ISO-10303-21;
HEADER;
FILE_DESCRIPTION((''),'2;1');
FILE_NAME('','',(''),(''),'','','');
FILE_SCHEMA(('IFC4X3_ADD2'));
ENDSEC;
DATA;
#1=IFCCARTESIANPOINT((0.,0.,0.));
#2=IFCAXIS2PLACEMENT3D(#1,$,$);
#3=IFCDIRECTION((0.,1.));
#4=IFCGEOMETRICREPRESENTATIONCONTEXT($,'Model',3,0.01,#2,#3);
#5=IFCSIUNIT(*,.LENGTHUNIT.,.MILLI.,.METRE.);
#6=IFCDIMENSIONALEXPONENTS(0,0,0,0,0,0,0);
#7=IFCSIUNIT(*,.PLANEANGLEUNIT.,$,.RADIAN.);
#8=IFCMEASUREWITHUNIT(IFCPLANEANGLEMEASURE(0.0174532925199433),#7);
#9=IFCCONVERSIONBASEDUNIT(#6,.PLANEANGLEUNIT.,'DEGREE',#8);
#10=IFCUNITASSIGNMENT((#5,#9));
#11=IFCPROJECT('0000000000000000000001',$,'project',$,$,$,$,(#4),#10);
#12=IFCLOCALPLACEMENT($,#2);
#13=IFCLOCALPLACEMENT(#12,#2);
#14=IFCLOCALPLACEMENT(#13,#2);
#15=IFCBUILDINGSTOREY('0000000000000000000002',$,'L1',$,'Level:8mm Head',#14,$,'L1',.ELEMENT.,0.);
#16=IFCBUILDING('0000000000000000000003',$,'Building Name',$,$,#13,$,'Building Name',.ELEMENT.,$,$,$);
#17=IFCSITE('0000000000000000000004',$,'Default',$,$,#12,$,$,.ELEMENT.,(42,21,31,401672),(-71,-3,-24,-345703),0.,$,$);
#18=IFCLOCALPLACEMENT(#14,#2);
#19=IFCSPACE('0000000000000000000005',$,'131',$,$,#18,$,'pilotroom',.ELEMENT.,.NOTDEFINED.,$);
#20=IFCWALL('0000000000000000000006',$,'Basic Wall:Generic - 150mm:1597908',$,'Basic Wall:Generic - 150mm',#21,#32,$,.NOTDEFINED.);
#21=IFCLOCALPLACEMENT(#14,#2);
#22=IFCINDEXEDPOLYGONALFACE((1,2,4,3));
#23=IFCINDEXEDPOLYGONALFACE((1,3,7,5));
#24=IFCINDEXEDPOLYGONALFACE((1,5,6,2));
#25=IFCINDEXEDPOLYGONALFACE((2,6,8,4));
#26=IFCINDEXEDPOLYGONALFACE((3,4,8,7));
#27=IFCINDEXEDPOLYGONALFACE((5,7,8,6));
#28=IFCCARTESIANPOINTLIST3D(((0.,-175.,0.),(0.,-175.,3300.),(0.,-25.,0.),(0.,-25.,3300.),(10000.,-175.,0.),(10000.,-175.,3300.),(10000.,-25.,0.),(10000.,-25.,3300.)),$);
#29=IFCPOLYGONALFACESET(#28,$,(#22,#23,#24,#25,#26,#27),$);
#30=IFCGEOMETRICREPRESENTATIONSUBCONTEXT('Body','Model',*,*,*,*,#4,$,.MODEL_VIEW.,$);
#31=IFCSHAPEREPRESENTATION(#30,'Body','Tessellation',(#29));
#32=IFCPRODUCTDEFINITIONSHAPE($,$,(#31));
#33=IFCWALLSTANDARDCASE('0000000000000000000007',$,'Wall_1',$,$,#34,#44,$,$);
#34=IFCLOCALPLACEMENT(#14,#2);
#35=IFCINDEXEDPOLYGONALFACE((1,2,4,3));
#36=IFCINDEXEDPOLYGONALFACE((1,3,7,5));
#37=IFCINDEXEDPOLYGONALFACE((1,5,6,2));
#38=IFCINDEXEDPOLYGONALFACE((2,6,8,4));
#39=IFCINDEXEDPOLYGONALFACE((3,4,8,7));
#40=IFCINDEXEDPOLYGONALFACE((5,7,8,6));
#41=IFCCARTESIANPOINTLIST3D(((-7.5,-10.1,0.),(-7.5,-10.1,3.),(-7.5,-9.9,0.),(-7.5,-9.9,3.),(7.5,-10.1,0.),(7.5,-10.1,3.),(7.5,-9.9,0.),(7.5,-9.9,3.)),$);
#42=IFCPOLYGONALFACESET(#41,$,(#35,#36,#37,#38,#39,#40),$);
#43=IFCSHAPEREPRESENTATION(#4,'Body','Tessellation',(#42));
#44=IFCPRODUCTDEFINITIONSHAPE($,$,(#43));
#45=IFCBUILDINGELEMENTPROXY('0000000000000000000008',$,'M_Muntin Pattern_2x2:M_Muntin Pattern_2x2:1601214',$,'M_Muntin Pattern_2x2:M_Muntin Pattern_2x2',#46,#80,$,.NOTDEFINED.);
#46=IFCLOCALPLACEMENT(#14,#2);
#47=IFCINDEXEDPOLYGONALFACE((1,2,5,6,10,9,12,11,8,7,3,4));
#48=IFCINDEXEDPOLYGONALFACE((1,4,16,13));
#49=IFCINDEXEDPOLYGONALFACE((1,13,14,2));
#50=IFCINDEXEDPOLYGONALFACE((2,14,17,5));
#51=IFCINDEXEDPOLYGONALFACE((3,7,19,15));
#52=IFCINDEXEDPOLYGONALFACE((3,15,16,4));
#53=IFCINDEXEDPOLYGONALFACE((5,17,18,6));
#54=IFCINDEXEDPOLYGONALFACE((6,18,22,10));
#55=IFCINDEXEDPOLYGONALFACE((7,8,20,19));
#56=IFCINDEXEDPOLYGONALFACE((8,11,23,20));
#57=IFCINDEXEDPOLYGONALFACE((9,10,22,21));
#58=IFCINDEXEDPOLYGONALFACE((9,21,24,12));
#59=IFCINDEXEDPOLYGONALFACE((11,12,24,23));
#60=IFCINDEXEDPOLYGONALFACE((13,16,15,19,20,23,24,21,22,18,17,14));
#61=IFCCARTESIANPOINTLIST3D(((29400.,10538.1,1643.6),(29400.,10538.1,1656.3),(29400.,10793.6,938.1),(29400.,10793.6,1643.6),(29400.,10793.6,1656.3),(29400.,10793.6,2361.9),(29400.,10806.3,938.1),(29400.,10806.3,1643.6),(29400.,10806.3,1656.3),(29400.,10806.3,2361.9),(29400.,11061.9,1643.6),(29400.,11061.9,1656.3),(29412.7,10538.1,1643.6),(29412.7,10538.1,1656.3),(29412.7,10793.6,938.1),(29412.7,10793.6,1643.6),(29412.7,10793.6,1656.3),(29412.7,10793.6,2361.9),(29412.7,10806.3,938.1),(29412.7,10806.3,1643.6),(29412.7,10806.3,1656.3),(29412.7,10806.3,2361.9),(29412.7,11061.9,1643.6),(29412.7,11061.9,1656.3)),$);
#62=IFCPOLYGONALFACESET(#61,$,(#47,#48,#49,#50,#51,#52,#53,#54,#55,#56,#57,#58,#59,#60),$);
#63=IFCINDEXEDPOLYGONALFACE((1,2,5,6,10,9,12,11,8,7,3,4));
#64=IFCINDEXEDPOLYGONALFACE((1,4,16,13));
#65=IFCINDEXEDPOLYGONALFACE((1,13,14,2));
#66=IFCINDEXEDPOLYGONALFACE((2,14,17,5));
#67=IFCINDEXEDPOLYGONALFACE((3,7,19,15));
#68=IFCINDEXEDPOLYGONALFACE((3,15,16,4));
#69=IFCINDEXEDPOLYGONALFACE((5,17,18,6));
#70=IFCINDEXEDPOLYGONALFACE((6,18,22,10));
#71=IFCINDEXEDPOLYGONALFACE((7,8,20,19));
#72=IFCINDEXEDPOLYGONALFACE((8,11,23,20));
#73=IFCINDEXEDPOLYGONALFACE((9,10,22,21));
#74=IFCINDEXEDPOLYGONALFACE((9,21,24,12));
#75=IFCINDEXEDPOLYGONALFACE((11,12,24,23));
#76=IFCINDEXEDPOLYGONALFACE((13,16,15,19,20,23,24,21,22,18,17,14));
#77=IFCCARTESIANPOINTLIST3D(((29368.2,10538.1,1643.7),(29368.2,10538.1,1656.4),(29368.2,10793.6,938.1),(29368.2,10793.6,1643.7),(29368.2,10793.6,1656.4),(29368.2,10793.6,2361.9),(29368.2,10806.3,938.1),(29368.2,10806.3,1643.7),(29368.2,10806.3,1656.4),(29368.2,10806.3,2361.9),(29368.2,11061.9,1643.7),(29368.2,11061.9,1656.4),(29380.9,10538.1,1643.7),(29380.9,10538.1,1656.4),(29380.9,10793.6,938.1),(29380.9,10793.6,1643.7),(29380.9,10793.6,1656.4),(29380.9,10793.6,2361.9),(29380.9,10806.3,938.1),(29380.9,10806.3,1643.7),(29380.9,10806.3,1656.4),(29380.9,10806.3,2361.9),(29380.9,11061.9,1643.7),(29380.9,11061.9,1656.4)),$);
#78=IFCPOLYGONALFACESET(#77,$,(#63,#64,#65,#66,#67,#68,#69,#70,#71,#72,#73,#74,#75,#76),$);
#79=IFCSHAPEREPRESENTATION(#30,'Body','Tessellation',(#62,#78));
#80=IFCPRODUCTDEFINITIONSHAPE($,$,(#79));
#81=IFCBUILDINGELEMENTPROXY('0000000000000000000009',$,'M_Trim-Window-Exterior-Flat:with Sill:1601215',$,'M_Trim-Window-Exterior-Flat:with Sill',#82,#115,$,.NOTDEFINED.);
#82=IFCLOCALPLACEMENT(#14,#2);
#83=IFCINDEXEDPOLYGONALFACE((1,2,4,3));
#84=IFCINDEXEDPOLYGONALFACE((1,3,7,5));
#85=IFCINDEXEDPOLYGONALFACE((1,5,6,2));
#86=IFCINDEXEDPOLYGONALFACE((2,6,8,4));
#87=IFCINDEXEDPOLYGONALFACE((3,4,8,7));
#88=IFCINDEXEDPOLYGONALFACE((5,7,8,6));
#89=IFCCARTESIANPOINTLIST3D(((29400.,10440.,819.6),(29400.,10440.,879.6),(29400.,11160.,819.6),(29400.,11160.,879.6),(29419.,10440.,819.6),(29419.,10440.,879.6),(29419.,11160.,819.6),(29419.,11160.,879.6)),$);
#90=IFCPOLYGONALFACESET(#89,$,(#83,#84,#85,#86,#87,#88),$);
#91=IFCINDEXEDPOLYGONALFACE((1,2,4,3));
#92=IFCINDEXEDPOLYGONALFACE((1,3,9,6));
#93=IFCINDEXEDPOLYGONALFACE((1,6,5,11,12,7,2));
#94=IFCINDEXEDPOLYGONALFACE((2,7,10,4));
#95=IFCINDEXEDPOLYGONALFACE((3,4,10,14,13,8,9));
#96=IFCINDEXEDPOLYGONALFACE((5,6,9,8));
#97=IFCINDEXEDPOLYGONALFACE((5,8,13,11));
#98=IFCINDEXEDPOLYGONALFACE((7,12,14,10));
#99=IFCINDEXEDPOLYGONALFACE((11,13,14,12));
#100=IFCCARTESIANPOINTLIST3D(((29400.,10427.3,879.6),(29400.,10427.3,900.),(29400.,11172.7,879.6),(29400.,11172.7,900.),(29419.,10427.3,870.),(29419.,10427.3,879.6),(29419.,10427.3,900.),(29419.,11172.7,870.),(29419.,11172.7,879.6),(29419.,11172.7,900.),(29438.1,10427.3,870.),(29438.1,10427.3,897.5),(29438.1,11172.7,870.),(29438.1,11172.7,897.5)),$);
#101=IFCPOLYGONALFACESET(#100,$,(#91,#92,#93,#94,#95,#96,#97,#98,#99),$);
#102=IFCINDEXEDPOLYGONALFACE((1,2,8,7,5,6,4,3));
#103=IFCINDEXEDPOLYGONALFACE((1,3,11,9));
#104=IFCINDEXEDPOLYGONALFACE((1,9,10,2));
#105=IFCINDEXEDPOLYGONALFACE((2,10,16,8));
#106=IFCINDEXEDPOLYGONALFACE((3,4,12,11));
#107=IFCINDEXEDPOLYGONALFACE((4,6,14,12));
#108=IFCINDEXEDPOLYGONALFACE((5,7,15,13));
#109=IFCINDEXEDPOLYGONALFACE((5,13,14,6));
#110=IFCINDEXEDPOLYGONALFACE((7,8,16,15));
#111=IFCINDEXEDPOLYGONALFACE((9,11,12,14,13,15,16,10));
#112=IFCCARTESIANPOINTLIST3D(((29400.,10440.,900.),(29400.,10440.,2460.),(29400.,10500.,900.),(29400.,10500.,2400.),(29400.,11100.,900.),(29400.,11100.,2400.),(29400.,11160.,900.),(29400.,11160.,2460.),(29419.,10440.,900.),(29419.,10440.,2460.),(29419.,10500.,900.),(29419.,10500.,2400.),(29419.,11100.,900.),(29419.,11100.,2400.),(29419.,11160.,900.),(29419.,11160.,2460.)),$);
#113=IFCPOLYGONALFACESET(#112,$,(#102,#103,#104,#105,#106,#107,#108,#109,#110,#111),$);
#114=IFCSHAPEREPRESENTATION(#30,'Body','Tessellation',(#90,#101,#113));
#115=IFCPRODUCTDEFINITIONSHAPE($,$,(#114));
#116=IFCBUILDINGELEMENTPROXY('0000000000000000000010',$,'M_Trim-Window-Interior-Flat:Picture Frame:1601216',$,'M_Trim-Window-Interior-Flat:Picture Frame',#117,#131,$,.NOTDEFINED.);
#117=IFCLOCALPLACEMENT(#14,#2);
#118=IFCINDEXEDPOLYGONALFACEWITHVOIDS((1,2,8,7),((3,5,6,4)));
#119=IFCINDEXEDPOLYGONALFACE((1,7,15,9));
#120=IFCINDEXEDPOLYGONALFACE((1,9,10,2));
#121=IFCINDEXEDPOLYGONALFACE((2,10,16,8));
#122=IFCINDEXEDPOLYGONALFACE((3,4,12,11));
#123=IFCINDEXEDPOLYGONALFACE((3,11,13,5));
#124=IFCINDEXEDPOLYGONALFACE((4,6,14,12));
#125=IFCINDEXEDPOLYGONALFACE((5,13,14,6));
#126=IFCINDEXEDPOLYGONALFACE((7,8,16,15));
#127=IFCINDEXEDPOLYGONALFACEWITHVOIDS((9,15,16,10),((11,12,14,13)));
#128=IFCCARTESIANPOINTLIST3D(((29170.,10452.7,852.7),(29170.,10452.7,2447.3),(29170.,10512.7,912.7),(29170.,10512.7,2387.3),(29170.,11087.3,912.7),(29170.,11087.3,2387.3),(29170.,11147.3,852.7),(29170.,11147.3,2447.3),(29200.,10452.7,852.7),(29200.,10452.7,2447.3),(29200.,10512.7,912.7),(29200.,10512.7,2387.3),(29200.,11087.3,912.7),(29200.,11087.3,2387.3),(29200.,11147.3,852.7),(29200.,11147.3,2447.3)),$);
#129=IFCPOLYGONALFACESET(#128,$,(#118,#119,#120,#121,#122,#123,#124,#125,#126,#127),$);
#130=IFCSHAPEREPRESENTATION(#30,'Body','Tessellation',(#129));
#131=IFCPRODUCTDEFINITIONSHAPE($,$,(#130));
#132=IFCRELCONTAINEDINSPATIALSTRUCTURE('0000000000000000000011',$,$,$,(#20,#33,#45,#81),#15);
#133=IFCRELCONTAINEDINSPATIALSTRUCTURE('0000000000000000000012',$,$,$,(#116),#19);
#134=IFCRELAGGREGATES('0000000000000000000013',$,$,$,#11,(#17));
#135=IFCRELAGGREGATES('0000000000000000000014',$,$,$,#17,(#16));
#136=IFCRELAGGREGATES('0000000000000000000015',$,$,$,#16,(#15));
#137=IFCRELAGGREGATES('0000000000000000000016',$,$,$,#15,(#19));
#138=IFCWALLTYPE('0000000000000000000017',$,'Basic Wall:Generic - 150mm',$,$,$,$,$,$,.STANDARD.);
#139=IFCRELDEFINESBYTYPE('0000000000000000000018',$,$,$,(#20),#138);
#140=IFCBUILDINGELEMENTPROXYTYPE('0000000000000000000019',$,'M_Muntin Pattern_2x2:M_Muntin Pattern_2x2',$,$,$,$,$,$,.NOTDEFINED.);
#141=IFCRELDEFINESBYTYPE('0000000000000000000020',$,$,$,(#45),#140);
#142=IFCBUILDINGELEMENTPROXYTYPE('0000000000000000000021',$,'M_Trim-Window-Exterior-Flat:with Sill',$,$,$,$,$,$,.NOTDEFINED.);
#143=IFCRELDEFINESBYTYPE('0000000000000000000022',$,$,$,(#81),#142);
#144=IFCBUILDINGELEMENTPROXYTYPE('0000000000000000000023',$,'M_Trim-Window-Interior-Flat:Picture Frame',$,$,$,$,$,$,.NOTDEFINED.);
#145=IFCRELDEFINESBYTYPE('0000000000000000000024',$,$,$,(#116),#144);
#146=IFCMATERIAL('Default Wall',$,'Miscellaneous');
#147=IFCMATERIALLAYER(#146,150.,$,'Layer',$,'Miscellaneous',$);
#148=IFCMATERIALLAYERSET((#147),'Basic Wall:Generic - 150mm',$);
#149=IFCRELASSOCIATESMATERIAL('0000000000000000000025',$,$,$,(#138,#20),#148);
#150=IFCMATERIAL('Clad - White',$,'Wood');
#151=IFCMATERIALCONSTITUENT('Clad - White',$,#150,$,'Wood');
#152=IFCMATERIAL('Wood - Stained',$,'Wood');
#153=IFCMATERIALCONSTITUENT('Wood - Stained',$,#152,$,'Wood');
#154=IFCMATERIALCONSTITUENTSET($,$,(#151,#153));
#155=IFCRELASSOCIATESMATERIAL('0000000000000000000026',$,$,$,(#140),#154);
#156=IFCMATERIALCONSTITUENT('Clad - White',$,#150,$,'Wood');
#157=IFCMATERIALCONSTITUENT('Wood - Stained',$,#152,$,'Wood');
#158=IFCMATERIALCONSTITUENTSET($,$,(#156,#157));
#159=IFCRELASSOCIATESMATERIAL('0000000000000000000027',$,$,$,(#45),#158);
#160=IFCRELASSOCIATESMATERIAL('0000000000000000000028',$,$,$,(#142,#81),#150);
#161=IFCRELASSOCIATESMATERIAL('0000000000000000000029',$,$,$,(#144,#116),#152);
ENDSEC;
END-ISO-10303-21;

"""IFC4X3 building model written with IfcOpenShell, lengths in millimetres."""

from ifc_helpers import new_model, entity, si_unit, converted_unit, direction, frame, frame_2d, origin, origin_with_axes, origin_2d, place, context, subcontext, project, spatial, polyline, rectangle, outline, extrude, source, transform, mapped, material, layer, layer_set, constituent, constituent_set, type_object, type_shapes, element, save


model = new_model("IFC4X3")

# Units and contexts
model_context = context("Model", 3, precision=0.01, world=origin(), true_north=direction((0.0, 1.0)))
body_context = subcontext(model_context, "Body", "Model", "MODEL_VIEW")
ifc_project = project(units=[si_unit("LENGTHUNIT", "METRE", prefix="MILLI"), converted_unit("PLANEANGLEUNIT", "DEGREE", entity("IfcPlaneAngleMeasure", 0.0174532925199433), si_unit("PLANEANGLEUNIT", "RADIAN"), dimensions=[0, 0, 0, 0, 0, 0, 0])], contexts=[model_context])

# Site, building, storey
site_placement = place(None, origin())
site = spatial("IfcSite", under=ifc_project, at=site_placement, Name="Default", CompositionType="ELEMENT", RefLatitude=(42, 21, 31, 401672), RefLongitude=(-71, -3, -24, -345703), RefElevation=0.0)
building_placement = place(site_placement, origin())
building = spatial("IfcBuilding", under=site, at=building_placement, Name="Building Name", LongName="Building Name", CompositionType="ELEMENT")
storey_placement = place(building_placement, origin())
storey = spatial("IfcBuildingStorey", under=building, at=storey_placement, Name="L1", ObjectType="Level:8mm Head", LongName="L1", CompositionType="ELEMENT", Elevation=0.0)

# Shared definitions
ifc_material_1 = material(Name="Default Wall", Category="Miscellaneous")

# Walls
ifc_layer_1 = layer(ifc_material_1, 150.0, Name="Layer", Category="Miscellaneous")
ifc_layer_set_1 = layer_set([ifc_layer_1], Name="Basic Wall:Generic - 150mm")
wall_type_1 = type_object("IfcWallType", Name="Basic Wall:Generic - 150mm", PredefinedType="STANDARD", material=ifc_layer_set_1)
wall_1_placement = place(storey_placement, frame((0.0, -100.0, 0.0)))
element("IfcWall", 1, at=wall_1_placement, inside=storey, type_object=wall_type_1, material=ifc_layer_set_1, Name="Basic Wall:Generic - 150mm:1597908", ObjectType="Basic Wall:Generic - 150mm", PredefinedType="NOTDEFINED", context=body_context, shape_type="SweptSolid", body=[
    extrude(rectangle(XDim=10000.0, YDim=150.0, at=frame_2d((5000.0, 0.0), x_axis=(-1.0, 0.0))), origin(), (0.0, 0.0, 1.0), 3300.0),
])
wall_2_placement = place(storey_placement, frame((0.0, -10.0, 0.0), z_axis=(0.0, 0.0, 1.0), x_axis=(1.0, 0.0, 0.0)))
element("IfcWallStandardCase", 2, at=wall_2_placement, inside=storey, Name="Wall_1", context=model_context, shape_type="SweptSolid", body=[
    extrude(rectangle(XDim=15.0, YDim=0.2, at=origin_2d()), origin_with_axes(), (0.0, 0.0, 1.0), 3.0),
])

# Building element proxies
ifc_material_2 = material(Name="Clad - White", Category="Wood")
ifc_constituent_1 = constituent(ifc_material_2, Name="Clad - White", Category="Wood")
ifc_material_3 = material(Name="Wood - Stained", Category="Wood")
ifc_constituent_2 = constituent(ifc_material_3, Name="Wood - Stained", Category="Wood")
ifc_constituent_set_1 = constituent_set(constituents=[ifc_constituent_1, ifc_constituent_2])
ifc_constituent_3 = constituent(ifc_material_2, Name="Clad - White", Category="Wood")
ifc_constituent_4 = constituent(ifc_material_3, Name="Wood - Stained", Category="Wood")
ifc_constituent_set_2 = constituent_set(constituents=[ifc_constituent_3, ifc_constituent_4])
building_element_proxy_type_1 = type_object("IfcBuildingElementProxyType", Name="M_Muntin Pattern_2x2:M_Muntin Pattern_2x2", PredefinedType="NOTDEFINED", material=ifc_constituent_set_2)
shared_shape_1 = source(origin(), body_context, "Body", "SweptSolid", [
    extrude(outline(polyline([(6.4, -6.4), (711.9, -6.4), (711.9, 6.3), (6.4, 6.3), (6.4, 261.9), (-6.3, 261.9), (-6.3, 6.3), (-711.9, 6.3), (-711.9, -6.4), (-6.3, -6.4), (-6.3, -261.9), (6.4, -261.9), (6.4, -6.4)])), frame((0.0, -22.2, 711.9), z_axis=(0.0, 1.0, 0.0), x_axis=(0.0, 0.0, 1.0)), (0.0, 0.0, 1.0), 12.7),
    extrude(outline(polyline([(6.4, -6.4), (711.9, -6.4), (711.9, 6.3), (6.4, 6.3), (6.4, 261.9), (-6.3, 261.9), (-6.3, 6.3), (-711.9, 6.3), (-711.9, -6.4), (-6.3, -6.4), (-6.3, -261.9), (6.4, -261.9), (6.4, -6.4)])), frame((0.0, 9.5, 711.9), z_axis=(0.0, 1.0, 0.0), x_axis=(0.0, 0.0, 1.0)), (0.0, 0.0, 1.0), 12.7),
])
type_shapes(building_element_proxy_type_1, [shared_shape_1])
proxy_1_placement = place(storey_placement, frame((29390.5, 10800.0, 938.1), z_axis=(0.0, 0.0, 1.0), x_axis=(0.0, 1.0, 0.0)))
element("IfcBuildingElementProxy", 3, at=proxy_1_placement, inside=storey, type_object=building_element_proxy_type_1, material=ifc_constituent_set_1, Name="M_Muntin Pattern_2x2:M_Muntin Pattern_2x2:1601214", ObjectType="M_Muntin Pattern_2x2:M_Muntin Pattern_2x2", PredefinedType="NOTDEFINED", context=body_context, shape_type="MappedRepresentation", body=[
    mapped(shared_shape_1, transform((0.0, 0.0, 0.0), scale=1.0)),
])
building_element_proxy_type_2 = type_object("IfcBuildingElementProxyType", Name="M_Trim-Window-Exterior-Flat:with Sill", PredefinedType="NOTDEFINED", material=ifc_material_2)
shared_shape_2 = source(origin(), body_context, "Body", "SweptSolid", [
    extrude(rectangle(XDim=720.0, YDim=60.0, at=frame_2d((0.0, 0.0), x_axis=(1.0, 0.0))), frame((0.0, -1550.4, 0.0), z_axis=(0.0, 0.0, 1.0), x_axis=(-1.0, 0.0, 0.0)), (0.0, 0.0, 1.0), 19.1),
    extrude(outline(polyline([(-19.0, -15.2), (0.0, -15.2), (0.0, -5.7), (19.0, -5.7), (19.0, 14.8), (0.0, 14.8), (-19.0, 12.3), (-19.0, -15.2)])), frame((-372.7, -1514.8, 19.0), z_axis=(1.0, 0.0, 0.0), x_axis=(0.0, 0.0, -1.0)), (0.0, 0.0, 1.0), 745.4),
    extrude(outline(polyline([(-795.0, -360.0), (765.0, -360.0), (765.0, -300.0), (-735.0, -300.0), (-735.0, 300.0), (765.0, 300.0), (765.0, 360.0), (-795.0, 360.0), (-795.0, -360.0)])), frame((0.0, -735.0, 0.0), z_axis=(0.0, 0.0, 1.0), x_axis=(0.0, -1.0, 0.0)), (0.0, 0.0, 1.0), 19.1),
])
type_shapes(building_element_proxy_type_2, [shared_shape_2])
proxy_2_placement = place(storey_placement, frame((29400.0, 10800.0, 2400.0), z_axis=(1.0, 0.0, 0.0), x_axis=(0.0, 1.0, 0.0)))
element("IfcBuildingElementProxy", 4, at=proxy_2_placement, inside=storey, type_object=building_element_proxy_type_2, material=ifc_material_2, Name="M_Trim-Window-Exterior-Flat:with Sill:1601215", ObjectType="M_Trim-Window-Exterior-Flat:with Sill", PredefinedType="NOTDEFINED", context=body_context, shape_type="MappedRepresentation", body=[
    mapped(shared_shape_2, transform((0.0, 0.0, 0.0), scale=1.0)),
])

# Shared definitions
space_placement = place(storey_placement, origin())
space = spatial("IfcSpace", under=storey, at=space_placement, Name="131", LongName="pilotroom", CompositionType="ELEMENT", PredefinedType="NOTDEFINED")

# Building element proxy
building_element_proxy_type_3 = type_object("IfcBuildingElementProxyType", Name="M_Trim-Window-Interior-Flat:Picture Frame", PredefinedType="NOTDEFINED", material=ifc_material_3)
shared_shape_3 = source(origin(), body_context, "Body", "SweptSolid", [
    extrude(outline(polyline([(-347.3, -797.3), (347.3, -797.3), (347.3, 797.3), (-347.3, 797.3), (-347.3, -797.3)]), holes=[polyline([(-287.3, -737.3), (-287.3, 737.3), (287.3, 737.3), (287.3, -737.3), (-287.3, -737.3)])]), frame((0.0, -750.0, 0.0), z_axis=(0.0, 0.0, 1.0), x_axis=(-1.0, 0.0, 0.0)), (0.0, 0.0, 1.0), 30.0),
])
type_shapes(building_element_proxy_type_3, [shared_shape_3])
proxy_3_placement = place(space_placement, frame((29200.0, 10800.0, 2400.0), z_axis=(-1.0, 0.0, 0.0), x_axis=(0.0, -1.0, 0.0)))
element("IfcBuildingElementProxy", 5, at=proxy_3_placement, inside=space, type_object=building_element_proxy_type_3, material=ifc_material_3, Name="M_Trim-Window-Interior-Flat:Picture Frame:1601216", ObjectType="M_Trim-Window-Interior-Flat:Picture Frame", PredefinedType="NOTDEFINED", context=body_context, shape_type="MappedRepresentation", body=[
    mapped(shared_shape_3, transform((0.0, 0.0, 0.0), scale=1.0)),
])

save(model, "model.ifc")
